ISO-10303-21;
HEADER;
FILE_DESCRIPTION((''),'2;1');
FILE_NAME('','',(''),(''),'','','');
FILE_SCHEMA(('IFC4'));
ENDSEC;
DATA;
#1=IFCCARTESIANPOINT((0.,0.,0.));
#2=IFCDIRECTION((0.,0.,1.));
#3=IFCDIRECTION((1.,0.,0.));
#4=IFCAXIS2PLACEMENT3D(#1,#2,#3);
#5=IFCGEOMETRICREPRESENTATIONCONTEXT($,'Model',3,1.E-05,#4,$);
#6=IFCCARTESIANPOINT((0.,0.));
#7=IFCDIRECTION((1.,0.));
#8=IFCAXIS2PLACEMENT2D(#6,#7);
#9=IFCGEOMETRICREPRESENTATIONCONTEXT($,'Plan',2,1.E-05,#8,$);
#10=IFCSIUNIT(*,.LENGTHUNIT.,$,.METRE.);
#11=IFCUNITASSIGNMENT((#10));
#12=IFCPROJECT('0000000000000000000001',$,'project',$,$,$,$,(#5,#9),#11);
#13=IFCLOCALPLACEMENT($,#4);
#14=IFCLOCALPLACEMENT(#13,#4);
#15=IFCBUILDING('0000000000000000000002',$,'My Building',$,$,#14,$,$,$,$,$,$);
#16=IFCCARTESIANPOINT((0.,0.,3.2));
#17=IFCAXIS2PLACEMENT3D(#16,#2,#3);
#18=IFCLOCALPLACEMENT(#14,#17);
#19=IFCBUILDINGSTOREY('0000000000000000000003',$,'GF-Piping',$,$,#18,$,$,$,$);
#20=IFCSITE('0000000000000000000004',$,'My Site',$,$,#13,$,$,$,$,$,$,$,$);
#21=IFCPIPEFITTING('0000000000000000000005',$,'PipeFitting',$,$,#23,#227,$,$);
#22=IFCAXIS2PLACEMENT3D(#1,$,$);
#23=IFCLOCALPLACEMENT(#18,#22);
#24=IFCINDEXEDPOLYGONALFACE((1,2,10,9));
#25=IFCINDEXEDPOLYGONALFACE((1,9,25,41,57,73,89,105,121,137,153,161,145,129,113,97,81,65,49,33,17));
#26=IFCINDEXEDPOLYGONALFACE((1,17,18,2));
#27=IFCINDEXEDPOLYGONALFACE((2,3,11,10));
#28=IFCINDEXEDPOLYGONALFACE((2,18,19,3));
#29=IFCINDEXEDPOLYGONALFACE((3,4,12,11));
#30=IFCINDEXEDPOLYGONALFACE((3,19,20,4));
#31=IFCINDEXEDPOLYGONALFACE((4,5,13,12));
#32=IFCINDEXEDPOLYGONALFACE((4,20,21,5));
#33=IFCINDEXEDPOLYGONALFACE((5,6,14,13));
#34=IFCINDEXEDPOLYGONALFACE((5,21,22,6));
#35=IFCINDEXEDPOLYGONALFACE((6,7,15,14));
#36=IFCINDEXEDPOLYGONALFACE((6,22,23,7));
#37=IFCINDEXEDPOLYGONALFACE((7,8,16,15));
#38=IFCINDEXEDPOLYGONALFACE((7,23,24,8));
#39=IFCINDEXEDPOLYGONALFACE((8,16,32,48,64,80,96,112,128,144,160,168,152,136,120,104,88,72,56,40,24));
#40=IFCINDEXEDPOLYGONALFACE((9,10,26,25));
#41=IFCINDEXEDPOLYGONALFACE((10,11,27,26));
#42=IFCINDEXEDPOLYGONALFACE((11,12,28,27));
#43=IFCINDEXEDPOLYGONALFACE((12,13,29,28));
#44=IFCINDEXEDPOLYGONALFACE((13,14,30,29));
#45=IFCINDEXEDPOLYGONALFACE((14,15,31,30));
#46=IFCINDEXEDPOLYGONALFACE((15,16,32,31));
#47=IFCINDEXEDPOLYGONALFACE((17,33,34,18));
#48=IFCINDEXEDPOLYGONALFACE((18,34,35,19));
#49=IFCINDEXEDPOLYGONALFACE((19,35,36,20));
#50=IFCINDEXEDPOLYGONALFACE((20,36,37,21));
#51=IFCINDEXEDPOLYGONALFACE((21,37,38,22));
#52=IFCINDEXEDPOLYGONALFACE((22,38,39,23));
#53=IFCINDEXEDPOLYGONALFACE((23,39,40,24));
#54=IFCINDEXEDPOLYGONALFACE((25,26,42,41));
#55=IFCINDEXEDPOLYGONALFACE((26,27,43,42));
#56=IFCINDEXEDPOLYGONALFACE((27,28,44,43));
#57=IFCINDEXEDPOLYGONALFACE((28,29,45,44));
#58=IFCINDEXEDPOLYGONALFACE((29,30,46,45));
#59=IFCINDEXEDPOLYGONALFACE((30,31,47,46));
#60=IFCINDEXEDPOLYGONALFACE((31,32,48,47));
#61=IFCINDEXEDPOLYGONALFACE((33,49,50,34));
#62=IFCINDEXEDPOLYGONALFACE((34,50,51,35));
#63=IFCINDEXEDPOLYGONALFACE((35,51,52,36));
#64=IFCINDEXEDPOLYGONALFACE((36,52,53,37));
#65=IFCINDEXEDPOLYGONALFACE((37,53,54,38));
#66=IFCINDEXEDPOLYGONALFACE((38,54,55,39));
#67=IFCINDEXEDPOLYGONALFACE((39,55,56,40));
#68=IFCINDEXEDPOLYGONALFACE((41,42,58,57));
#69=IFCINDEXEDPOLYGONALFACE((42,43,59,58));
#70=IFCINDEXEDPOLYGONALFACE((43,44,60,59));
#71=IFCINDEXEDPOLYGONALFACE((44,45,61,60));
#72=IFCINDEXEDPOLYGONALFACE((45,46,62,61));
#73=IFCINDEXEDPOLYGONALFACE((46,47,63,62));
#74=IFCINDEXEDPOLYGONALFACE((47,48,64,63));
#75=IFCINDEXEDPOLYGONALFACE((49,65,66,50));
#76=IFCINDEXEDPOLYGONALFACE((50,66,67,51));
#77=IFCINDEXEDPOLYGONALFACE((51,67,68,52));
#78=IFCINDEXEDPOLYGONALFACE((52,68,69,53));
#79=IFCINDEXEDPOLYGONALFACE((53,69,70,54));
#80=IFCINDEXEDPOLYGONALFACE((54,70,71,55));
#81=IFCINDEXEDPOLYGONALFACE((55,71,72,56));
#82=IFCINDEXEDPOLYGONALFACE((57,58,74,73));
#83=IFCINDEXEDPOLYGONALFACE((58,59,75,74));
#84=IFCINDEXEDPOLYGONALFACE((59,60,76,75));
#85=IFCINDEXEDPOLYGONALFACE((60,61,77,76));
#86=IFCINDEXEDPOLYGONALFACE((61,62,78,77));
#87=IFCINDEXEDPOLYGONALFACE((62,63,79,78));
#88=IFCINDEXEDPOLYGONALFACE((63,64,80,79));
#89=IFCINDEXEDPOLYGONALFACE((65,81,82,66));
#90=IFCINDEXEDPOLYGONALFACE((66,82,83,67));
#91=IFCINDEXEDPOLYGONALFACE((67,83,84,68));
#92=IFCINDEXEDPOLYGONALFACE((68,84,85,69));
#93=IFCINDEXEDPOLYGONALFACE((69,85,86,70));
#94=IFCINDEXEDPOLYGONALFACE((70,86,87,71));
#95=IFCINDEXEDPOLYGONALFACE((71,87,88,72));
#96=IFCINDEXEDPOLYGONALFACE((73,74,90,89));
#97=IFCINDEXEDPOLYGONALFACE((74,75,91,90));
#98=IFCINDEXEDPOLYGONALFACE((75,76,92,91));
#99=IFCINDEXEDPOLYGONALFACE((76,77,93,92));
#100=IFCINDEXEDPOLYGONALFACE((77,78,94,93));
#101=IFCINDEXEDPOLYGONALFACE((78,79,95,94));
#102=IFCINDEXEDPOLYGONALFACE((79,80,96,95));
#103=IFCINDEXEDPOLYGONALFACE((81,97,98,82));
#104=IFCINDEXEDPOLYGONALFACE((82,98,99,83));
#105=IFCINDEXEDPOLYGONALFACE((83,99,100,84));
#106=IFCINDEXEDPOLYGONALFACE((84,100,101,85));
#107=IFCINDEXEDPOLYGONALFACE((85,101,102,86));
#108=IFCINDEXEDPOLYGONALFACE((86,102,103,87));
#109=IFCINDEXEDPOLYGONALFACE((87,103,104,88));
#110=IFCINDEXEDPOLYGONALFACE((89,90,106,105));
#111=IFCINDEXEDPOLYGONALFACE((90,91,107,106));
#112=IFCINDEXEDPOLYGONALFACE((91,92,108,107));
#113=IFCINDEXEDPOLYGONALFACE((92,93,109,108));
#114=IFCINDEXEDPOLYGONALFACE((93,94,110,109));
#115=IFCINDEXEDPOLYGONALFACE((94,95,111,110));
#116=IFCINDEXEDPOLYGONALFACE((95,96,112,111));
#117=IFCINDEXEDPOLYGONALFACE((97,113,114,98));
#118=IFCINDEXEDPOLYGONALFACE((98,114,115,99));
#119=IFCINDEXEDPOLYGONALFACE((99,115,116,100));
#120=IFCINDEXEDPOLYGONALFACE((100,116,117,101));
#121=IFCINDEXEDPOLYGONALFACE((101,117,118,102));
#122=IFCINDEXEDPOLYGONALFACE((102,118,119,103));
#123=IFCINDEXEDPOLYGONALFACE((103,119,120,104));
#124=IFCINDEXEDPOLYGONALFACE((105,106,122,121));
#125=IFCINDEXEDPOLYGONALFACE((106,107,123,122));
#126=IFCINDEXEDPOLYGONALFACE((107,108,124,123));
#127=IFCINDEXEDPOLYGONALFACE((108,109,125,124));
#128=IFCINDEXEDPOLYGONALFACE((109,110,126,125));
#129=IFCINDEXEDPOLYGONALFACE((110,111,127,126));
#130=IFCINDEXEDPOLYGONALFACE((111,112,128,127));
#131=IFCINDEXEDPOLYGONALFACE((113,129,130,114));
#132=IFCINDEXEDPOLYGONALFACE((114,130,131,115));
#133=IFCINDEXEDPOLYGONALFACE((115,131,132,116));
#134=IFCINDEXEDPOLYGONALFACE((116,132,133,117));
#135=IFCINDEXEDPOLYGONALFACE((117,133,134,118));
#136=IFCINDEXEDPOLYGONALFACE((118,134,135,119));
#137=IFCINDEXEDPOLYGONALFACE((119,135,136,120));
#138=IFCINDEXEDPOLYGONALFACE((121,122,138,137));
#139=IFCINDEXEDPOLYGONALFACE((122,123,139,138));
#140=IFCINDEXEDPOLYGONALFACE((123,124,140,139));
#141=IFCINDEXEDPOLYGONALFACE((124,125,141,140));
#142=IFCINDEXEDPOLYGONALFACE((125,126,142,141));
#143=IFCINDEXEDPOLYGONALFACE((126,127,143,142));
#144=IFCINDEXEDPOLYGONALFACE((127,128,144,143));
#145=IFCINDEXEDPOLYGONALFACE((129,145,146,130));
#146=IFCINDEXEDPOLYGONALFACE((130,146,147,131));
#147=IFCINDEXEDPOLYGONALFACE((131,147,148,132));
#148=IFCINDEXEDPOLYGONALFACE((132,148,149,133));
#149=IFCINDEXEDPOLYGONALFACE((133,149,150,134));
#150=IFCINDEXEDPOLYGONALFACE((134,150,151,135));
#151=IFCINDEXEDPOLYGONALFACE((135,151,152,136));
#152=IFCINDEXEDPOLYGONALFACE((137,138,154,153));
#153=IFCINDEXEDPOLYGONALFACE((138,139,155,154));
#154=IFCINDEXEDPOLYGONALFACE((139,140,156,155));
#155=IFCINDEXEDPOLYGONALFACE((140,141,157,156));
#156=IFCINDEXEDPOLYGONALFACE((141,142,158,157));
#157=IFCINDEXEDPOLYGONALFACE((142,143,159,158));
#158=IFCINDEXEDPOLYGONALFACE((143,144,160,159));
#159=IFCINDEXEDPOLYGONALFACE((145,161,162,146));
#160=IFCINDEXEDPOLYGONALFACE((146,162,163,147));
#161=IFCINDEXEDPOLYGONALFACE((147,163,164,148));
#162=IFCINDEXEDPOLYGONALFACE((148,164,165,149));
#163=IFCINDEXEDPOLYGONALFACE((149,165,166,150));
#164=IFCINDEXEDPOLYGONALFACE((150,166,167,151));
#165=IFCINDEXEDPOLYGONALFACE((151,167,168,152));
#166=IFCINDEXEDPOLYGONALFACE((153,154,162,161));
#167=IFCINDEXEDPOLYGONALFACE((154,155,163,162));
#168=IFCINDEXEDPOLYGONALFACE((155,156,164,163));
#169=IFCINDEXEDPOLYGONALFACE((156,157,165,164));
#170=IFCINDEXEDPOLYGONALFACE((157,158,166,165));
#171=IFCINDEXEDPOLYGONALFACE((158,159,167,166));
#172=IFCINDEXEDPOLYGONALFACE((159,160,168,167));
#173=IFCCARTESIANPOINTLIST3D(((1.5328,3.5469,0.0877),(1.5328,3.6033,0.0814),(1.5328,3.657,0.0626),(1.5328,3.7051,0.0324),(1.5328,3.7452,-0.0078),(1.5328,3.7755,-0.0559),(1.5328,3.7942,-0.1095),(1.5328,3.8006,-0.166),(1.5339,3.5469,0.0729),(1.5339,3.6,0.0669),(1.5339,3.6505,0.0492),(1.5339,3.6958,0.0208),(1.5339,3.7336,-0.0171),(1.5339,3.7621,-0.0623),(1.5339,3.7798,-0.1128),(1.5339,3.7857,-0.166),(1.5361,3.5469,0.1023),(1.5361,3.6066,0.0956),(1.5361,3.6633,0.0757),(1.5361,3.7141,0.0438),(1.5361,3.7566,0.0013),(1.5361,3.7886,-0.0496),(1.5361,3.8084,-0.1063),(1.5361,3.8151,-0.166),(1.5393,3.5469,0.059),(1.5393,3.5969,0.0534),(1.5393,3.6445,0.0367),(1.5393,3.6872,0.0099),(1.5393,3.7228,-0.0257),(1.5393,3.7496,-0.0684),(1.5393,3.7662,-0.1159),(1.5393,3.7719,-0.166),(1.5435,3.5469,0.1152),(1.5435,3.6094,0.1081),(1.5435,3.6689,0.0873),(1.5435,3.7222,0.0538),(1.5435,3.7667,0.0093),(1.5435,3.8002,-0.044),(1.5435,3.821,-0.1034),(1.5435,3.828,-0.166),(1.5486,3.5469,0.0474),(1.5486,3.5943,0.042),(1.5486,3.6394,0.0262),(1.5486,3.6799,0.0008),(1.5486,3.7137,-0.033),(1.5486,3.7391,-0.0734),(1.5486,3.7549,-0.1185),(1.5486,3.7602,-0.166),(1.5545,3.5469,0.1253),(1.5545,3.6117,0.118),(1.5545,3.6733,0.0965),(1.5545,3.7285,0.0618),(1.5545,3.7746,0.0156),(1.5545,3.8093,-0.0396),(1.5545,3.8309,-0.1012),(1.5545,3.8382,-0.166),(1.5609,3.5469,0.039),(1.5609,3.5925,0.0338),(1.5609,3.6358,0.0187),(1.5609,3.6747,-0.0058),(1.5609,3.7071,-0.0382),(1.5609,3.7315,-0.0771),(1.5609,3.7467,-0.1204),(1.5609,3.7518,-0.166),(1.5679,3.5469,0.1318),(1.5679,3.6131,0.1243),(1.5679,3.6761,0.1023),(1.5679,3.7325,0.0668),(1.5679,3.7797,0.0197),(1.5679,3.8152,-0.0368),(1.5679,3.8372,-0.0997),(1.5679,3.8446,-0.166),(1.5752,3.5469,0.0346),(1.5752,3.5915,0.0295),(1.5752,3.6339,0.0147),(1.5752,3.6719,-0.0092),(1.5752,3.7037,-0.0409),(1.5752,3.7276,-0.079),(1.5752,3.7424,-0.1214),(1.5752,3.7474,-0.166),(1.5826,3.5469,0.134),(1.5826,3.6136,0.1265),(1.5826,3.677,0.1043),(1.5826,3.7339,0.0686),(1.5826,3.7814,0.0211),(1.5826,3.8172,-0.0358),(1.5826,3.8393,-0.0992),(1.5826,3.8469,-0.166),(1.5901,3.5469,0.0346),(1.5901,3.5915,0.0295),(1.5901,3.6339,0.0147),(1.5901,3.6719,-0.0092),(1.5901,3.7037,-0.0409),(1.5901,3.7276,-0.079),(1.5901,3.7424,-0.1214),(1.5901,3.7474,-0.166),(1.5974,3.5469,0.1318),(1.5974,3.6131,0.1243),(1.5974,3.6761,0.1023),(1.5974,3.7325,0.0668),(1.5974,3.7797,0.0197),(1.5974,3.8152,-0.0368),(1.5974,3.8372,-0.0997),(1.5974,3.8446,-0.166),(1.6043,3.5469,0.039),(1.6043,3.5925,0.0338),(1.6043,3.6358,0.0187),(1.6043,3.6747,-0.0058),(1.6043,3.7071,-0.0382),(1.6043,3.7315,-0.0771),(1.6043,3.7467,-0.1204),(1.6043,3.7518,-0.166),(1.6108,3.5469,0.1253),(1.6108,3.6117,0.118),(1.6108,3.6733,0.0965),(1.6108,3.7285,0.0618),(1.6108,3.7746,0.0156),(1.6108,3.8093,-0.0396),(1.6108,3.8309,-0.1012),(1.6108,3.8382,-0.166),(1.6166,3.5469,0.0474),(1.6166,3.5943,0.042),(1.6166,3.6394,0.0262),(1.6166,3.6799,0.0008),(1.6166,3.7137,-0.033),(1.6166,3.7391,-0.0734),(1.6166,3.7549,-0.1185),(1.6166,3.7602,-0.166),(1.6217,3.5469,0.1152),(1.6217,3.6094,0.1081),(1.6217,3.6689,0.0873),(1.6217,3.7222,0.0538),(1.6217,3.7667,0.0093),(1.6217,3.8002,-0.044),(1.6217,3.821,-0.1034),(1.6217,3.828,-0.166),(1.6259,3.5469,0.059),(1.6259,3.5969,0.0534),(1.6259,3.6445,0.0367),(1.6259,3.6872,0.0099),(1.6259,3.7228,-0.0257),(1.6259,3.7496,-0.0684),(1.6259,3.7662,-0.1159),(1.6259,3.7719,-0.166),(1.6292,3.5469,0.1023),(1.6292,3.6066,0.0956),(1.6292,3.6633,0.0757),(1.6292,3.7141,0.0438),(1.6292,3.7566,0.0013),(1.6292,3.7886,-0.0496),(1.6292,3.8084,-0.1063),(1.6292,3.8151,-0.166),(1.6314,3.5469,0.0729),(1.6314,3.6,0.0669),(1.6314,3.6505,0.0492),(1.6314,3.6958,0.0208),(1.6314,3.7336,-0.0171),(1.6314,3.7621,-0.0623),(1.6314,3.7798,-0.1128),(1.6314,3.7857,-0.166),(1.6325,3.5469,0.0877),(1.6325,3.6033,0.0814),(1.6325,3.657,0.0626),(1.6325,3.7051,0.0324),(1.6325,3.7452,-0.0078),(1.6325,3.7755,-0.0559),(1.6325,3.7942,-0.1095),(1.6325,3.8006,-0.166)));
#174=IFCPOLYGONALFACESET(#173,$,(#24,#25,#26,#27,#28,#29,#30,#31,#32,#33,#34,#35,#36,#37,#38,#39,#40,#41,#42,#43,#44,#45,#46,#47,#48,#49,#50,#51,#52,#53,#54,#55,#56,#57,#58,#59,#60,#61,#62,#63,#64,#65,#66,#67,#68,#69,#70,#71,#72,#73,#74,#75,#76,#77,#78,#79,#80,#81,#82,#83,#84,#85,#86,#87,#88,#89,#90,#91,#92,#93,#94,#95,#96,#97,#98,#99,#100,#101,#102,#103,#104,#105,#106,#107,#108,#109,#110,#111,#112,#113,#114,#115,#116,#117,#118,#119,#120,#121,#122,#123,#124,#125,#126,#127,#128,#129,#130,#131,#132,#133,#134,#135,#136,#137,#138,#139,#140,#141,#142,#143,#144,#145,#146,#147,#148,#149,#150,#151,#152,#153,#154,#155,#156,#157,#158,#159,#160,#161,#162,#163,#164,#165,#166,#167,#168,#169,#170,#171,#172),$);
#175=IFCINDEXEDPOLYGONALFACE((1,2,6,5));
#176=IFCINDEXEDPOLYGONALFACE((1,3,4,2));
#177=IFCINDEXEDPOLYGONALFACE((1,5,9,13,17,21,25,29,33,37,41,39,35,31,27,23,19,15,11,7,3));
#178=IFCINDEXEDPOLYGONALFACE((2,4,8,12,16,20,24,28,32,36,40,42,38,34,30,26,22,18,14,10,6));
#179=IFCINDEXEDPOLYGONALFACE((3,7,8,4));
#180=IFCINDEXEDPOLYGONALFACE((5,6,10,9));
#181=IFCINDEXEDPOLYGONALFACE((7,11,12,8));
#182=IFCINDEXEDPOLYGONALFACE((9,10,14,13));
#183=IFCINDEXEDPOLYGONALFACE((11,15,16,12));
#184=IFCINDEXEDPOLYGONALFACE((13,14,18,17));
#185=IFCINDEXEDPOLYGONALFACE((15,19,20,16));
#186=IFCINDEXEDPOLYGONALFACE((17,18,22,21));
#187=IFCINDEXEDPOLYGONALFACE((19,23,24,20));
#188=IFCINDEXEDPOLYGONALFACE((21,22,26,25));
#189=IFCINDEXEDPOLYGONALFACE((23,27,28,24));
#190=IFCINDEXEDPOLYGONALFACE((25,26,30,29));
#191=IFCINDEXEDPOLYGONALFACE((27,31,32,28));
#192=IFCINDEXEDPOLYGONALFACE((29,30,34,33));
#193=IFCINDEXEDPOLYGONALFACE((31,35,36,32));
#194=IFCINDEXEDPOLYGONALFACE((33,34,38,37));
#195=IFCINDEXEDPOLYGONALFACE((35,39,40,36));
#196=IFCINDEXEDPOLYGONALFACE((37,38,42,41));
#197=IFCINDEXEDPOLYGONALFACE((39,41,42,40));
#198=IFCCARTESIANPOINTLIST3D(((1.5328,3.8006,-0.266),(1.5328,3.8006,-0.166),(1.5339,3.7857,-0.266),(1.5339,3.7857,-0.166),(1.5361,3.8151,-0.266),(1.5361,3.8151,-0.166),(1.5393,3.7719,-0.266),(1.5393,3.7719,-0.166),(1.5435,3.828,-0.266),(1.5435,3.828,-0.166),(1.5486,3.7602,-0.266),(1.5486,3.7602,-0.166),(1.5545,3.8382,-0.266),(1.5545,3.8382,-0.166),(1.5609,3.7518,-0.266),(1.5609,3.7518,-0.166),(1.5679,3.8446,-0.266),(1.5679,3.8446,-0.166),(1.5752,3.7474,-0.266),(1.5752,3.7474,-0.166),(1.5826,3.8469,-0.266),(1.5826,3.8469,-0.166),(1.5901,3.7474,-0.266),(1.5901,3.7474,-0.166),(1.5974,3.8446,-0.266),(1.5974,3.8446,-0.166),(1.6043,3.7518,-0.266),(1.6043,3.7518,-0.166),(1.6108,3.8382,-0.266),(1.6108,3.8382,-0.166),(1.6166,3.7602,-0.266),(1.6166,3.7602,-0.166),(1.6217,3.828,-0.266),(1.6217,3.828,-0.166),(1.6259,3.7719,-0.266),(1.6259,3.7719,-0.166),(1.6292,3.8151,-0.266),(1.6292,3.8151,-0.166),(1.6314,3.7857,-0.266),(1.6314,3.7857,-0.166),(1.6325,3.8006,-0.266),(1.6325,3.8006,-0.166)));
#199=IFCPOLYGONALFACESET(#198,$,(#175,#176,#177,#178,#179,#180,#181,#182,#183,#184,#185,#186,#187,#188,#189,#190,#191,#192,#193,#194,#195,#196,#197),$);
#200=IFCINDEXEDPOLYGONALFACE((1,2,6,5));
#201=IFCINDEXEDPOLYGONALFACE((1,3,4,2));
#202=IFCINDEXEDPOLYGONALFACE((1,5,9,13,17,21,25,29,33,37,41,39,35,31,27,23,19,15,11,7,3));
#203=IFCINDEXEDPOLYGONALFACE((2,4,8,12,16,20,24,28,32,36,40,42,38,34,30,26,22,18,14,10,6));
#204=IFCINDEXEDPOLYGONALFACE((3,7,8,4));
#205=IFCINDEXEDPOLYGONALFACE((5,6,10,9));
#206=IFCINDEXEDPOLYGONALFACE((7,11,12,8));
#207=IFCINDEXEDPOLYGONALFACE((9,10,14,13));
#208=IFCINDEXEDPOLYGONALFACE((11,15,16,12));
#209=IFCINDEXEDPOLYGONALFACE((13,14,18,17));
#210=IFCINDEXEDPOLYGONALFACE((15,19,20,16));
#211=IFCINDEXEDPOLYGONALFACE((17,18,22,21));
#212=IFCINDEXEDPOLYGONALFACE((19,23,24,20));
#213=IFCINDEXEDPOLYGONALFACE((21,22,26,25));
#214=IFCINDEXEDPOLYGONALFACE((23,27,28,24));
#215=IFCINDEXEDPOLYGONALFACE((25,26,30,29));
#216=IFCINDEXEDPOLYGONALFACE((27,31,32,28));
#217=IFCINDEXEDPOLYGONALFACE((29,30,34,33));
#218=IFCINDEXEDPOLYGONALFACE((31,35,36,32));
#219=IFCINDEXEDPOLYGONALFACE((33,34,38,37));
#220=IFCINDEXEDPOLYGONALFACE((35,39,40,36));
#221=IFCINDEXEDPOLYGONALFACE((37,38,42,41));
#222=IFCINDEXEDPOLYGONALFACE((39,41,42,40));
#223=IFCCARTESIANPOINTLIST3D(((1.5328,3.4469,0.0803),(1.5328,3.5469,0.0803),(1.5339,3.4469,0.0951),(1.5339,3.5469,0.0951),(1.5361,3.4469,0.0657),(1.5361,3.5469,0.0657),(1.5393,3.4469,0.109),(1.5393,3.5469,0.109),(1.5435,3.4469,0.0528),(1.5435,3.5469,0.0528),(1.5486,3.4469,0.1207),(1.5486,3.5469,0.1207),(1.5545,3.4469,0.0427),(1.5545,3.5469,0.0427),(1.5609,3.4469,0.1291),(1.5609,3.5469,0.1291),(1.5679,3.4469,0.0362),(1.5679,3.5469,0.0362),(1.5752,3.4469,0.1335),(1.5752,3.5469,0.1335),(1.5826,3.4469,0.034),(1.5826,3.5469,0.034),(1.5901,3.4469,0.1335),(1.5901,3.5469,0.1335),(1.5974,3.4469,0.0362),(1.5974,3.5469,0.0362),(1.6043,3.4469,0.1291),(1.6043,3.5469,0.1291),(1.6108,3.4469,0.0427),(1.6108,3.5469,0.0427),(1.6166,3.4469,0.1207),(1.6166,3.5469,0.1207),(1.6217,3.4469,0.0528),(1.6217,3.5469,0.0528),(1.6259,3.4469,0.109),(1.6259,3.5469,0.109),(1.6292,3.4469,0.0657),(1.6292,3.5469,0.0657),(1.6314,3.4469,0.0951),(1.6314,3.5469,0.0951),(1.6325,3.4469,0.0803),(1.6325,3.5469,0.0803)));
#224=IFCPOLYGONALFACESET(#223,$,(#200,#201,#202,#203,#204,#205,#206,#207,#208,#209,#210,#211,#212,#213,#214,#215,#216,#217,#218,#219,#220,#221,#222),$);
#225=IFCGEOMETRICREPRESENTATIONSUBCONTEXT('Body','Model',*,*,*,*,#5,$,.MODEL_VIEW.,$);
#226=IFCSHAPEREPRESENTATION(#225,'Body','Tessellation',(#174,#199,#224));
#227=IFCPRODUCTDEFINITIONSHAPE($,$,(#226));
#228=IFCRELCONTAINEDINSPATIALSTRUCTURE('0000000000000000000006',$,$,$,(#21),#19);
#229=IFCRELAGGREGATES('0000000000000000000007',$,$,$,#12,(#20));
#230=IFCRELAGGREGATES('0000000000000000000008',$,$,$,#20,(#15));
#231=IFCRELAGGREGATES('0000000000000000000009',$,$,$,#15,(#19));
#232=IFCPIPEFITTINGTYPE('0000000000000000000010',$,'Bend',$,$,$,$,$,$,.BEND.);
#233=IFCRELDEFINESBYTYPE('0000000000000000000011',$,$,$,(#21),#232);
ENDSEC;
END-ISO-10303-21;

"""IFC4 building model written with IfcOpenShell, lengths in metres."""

from ifc_helpers import new_model, entity, si_unit, frame, origin_with_axes, origin_2d_with_axis, place, context, subcontext, project, spatial, circle, extrude, source, transform, mapped, type_object, type_shapes, element, save


model = new_model("IFC4")

# Units and contexts
model_context = context("Model", 3, precision=1e-05, world=origin_with_axes())
plan_context = context("Plan", 2, precision=1e-05, world=origin_2d_with_axis())
body_context = subcontext(model_context, "Body", "Model", "MODEL_VIEW")
ifc_project = project(units=[si_unit("LENGTHUNIT", "METRE")], contexts=[model_context, plan_context])

# Site, building, storey
site_placement = place(None, origin_with_axes())
site = spatial("IfcSite", under=ifc_project, at=site_placement, Name="My Site")
building_placement = place(site_placement, origin_with_axes())
building = spatial("IfcBuilding", under=site, at=building_placement, Name="My Building")
storey_placement = place(building_placement, frame((0.0, 0.0, 3.2), z_axis=(0.0, 0.0, 1.0), x_axis=(1.0, 0.0, 0.0)))
storey = spatial("IfcBuildingStorey", under=building, at=storey_placement, Name="GF-Piping")

# Pipe fitting
pipe_fitting_type = type_object("IfcPipeFittingType", Name="Bend", PredefinedType="BEND")
shared_shape = source(origin_with_axes(), body_context, "Body", "SolidModel", [
    entity("IfcSweptDiskSolid", entity("IfcIndexedPolyCurve", entity("IfcCartesianPointList3D", [[0.0, 0.0, 0.1], [-0.0732, 0.0, 0.2768], [-0.25, 0.0, 0.35]]), [entity("IfcArcIndex", [1, 2, 3])]), 0.05),
    extrude(circle(Radius=0.05), origin_with_axes(), (0.0, 0.0, 1.0), 0.1),
    extrude(circle(Radius=0.05), frame((-0.25, 0.0, 0.35), z_axis=(-1.0, 0.0, 0.0), x_axis=(0.0, 0.0, -1.0)), (0.0, 0.0, 1.0), 0.1),
])
type_shapes(pipe_fitting_type, [shared_shape])
for number, where, z_axis, x_axis, name in (
    (1, (1.5826, 3.7969, -0.266), (0.0, 0.0, 1.0), (0.0, 1.0, 0.0), "PipeFitting"),
):
    element("IfcPipeFitting", number, at=place(storey_placement, frame(where, z_axis=z_axis, x_axis=x_axis)), inside=storey, type_object=pipe_fitting_type, Name=name, context=body_context, shape_type="MappedRepresentation", body=[
        mapped(shared_shape, transform((0.0, 0.0, 0.0), x_axis=(1.0, 0.0, 0.0), y_axis=(0.0, 1.0, 0.0), z_axis=(0.0, 0.0, 1.0), scale=1.0)),
    ])

save(model, "model.ifc")
